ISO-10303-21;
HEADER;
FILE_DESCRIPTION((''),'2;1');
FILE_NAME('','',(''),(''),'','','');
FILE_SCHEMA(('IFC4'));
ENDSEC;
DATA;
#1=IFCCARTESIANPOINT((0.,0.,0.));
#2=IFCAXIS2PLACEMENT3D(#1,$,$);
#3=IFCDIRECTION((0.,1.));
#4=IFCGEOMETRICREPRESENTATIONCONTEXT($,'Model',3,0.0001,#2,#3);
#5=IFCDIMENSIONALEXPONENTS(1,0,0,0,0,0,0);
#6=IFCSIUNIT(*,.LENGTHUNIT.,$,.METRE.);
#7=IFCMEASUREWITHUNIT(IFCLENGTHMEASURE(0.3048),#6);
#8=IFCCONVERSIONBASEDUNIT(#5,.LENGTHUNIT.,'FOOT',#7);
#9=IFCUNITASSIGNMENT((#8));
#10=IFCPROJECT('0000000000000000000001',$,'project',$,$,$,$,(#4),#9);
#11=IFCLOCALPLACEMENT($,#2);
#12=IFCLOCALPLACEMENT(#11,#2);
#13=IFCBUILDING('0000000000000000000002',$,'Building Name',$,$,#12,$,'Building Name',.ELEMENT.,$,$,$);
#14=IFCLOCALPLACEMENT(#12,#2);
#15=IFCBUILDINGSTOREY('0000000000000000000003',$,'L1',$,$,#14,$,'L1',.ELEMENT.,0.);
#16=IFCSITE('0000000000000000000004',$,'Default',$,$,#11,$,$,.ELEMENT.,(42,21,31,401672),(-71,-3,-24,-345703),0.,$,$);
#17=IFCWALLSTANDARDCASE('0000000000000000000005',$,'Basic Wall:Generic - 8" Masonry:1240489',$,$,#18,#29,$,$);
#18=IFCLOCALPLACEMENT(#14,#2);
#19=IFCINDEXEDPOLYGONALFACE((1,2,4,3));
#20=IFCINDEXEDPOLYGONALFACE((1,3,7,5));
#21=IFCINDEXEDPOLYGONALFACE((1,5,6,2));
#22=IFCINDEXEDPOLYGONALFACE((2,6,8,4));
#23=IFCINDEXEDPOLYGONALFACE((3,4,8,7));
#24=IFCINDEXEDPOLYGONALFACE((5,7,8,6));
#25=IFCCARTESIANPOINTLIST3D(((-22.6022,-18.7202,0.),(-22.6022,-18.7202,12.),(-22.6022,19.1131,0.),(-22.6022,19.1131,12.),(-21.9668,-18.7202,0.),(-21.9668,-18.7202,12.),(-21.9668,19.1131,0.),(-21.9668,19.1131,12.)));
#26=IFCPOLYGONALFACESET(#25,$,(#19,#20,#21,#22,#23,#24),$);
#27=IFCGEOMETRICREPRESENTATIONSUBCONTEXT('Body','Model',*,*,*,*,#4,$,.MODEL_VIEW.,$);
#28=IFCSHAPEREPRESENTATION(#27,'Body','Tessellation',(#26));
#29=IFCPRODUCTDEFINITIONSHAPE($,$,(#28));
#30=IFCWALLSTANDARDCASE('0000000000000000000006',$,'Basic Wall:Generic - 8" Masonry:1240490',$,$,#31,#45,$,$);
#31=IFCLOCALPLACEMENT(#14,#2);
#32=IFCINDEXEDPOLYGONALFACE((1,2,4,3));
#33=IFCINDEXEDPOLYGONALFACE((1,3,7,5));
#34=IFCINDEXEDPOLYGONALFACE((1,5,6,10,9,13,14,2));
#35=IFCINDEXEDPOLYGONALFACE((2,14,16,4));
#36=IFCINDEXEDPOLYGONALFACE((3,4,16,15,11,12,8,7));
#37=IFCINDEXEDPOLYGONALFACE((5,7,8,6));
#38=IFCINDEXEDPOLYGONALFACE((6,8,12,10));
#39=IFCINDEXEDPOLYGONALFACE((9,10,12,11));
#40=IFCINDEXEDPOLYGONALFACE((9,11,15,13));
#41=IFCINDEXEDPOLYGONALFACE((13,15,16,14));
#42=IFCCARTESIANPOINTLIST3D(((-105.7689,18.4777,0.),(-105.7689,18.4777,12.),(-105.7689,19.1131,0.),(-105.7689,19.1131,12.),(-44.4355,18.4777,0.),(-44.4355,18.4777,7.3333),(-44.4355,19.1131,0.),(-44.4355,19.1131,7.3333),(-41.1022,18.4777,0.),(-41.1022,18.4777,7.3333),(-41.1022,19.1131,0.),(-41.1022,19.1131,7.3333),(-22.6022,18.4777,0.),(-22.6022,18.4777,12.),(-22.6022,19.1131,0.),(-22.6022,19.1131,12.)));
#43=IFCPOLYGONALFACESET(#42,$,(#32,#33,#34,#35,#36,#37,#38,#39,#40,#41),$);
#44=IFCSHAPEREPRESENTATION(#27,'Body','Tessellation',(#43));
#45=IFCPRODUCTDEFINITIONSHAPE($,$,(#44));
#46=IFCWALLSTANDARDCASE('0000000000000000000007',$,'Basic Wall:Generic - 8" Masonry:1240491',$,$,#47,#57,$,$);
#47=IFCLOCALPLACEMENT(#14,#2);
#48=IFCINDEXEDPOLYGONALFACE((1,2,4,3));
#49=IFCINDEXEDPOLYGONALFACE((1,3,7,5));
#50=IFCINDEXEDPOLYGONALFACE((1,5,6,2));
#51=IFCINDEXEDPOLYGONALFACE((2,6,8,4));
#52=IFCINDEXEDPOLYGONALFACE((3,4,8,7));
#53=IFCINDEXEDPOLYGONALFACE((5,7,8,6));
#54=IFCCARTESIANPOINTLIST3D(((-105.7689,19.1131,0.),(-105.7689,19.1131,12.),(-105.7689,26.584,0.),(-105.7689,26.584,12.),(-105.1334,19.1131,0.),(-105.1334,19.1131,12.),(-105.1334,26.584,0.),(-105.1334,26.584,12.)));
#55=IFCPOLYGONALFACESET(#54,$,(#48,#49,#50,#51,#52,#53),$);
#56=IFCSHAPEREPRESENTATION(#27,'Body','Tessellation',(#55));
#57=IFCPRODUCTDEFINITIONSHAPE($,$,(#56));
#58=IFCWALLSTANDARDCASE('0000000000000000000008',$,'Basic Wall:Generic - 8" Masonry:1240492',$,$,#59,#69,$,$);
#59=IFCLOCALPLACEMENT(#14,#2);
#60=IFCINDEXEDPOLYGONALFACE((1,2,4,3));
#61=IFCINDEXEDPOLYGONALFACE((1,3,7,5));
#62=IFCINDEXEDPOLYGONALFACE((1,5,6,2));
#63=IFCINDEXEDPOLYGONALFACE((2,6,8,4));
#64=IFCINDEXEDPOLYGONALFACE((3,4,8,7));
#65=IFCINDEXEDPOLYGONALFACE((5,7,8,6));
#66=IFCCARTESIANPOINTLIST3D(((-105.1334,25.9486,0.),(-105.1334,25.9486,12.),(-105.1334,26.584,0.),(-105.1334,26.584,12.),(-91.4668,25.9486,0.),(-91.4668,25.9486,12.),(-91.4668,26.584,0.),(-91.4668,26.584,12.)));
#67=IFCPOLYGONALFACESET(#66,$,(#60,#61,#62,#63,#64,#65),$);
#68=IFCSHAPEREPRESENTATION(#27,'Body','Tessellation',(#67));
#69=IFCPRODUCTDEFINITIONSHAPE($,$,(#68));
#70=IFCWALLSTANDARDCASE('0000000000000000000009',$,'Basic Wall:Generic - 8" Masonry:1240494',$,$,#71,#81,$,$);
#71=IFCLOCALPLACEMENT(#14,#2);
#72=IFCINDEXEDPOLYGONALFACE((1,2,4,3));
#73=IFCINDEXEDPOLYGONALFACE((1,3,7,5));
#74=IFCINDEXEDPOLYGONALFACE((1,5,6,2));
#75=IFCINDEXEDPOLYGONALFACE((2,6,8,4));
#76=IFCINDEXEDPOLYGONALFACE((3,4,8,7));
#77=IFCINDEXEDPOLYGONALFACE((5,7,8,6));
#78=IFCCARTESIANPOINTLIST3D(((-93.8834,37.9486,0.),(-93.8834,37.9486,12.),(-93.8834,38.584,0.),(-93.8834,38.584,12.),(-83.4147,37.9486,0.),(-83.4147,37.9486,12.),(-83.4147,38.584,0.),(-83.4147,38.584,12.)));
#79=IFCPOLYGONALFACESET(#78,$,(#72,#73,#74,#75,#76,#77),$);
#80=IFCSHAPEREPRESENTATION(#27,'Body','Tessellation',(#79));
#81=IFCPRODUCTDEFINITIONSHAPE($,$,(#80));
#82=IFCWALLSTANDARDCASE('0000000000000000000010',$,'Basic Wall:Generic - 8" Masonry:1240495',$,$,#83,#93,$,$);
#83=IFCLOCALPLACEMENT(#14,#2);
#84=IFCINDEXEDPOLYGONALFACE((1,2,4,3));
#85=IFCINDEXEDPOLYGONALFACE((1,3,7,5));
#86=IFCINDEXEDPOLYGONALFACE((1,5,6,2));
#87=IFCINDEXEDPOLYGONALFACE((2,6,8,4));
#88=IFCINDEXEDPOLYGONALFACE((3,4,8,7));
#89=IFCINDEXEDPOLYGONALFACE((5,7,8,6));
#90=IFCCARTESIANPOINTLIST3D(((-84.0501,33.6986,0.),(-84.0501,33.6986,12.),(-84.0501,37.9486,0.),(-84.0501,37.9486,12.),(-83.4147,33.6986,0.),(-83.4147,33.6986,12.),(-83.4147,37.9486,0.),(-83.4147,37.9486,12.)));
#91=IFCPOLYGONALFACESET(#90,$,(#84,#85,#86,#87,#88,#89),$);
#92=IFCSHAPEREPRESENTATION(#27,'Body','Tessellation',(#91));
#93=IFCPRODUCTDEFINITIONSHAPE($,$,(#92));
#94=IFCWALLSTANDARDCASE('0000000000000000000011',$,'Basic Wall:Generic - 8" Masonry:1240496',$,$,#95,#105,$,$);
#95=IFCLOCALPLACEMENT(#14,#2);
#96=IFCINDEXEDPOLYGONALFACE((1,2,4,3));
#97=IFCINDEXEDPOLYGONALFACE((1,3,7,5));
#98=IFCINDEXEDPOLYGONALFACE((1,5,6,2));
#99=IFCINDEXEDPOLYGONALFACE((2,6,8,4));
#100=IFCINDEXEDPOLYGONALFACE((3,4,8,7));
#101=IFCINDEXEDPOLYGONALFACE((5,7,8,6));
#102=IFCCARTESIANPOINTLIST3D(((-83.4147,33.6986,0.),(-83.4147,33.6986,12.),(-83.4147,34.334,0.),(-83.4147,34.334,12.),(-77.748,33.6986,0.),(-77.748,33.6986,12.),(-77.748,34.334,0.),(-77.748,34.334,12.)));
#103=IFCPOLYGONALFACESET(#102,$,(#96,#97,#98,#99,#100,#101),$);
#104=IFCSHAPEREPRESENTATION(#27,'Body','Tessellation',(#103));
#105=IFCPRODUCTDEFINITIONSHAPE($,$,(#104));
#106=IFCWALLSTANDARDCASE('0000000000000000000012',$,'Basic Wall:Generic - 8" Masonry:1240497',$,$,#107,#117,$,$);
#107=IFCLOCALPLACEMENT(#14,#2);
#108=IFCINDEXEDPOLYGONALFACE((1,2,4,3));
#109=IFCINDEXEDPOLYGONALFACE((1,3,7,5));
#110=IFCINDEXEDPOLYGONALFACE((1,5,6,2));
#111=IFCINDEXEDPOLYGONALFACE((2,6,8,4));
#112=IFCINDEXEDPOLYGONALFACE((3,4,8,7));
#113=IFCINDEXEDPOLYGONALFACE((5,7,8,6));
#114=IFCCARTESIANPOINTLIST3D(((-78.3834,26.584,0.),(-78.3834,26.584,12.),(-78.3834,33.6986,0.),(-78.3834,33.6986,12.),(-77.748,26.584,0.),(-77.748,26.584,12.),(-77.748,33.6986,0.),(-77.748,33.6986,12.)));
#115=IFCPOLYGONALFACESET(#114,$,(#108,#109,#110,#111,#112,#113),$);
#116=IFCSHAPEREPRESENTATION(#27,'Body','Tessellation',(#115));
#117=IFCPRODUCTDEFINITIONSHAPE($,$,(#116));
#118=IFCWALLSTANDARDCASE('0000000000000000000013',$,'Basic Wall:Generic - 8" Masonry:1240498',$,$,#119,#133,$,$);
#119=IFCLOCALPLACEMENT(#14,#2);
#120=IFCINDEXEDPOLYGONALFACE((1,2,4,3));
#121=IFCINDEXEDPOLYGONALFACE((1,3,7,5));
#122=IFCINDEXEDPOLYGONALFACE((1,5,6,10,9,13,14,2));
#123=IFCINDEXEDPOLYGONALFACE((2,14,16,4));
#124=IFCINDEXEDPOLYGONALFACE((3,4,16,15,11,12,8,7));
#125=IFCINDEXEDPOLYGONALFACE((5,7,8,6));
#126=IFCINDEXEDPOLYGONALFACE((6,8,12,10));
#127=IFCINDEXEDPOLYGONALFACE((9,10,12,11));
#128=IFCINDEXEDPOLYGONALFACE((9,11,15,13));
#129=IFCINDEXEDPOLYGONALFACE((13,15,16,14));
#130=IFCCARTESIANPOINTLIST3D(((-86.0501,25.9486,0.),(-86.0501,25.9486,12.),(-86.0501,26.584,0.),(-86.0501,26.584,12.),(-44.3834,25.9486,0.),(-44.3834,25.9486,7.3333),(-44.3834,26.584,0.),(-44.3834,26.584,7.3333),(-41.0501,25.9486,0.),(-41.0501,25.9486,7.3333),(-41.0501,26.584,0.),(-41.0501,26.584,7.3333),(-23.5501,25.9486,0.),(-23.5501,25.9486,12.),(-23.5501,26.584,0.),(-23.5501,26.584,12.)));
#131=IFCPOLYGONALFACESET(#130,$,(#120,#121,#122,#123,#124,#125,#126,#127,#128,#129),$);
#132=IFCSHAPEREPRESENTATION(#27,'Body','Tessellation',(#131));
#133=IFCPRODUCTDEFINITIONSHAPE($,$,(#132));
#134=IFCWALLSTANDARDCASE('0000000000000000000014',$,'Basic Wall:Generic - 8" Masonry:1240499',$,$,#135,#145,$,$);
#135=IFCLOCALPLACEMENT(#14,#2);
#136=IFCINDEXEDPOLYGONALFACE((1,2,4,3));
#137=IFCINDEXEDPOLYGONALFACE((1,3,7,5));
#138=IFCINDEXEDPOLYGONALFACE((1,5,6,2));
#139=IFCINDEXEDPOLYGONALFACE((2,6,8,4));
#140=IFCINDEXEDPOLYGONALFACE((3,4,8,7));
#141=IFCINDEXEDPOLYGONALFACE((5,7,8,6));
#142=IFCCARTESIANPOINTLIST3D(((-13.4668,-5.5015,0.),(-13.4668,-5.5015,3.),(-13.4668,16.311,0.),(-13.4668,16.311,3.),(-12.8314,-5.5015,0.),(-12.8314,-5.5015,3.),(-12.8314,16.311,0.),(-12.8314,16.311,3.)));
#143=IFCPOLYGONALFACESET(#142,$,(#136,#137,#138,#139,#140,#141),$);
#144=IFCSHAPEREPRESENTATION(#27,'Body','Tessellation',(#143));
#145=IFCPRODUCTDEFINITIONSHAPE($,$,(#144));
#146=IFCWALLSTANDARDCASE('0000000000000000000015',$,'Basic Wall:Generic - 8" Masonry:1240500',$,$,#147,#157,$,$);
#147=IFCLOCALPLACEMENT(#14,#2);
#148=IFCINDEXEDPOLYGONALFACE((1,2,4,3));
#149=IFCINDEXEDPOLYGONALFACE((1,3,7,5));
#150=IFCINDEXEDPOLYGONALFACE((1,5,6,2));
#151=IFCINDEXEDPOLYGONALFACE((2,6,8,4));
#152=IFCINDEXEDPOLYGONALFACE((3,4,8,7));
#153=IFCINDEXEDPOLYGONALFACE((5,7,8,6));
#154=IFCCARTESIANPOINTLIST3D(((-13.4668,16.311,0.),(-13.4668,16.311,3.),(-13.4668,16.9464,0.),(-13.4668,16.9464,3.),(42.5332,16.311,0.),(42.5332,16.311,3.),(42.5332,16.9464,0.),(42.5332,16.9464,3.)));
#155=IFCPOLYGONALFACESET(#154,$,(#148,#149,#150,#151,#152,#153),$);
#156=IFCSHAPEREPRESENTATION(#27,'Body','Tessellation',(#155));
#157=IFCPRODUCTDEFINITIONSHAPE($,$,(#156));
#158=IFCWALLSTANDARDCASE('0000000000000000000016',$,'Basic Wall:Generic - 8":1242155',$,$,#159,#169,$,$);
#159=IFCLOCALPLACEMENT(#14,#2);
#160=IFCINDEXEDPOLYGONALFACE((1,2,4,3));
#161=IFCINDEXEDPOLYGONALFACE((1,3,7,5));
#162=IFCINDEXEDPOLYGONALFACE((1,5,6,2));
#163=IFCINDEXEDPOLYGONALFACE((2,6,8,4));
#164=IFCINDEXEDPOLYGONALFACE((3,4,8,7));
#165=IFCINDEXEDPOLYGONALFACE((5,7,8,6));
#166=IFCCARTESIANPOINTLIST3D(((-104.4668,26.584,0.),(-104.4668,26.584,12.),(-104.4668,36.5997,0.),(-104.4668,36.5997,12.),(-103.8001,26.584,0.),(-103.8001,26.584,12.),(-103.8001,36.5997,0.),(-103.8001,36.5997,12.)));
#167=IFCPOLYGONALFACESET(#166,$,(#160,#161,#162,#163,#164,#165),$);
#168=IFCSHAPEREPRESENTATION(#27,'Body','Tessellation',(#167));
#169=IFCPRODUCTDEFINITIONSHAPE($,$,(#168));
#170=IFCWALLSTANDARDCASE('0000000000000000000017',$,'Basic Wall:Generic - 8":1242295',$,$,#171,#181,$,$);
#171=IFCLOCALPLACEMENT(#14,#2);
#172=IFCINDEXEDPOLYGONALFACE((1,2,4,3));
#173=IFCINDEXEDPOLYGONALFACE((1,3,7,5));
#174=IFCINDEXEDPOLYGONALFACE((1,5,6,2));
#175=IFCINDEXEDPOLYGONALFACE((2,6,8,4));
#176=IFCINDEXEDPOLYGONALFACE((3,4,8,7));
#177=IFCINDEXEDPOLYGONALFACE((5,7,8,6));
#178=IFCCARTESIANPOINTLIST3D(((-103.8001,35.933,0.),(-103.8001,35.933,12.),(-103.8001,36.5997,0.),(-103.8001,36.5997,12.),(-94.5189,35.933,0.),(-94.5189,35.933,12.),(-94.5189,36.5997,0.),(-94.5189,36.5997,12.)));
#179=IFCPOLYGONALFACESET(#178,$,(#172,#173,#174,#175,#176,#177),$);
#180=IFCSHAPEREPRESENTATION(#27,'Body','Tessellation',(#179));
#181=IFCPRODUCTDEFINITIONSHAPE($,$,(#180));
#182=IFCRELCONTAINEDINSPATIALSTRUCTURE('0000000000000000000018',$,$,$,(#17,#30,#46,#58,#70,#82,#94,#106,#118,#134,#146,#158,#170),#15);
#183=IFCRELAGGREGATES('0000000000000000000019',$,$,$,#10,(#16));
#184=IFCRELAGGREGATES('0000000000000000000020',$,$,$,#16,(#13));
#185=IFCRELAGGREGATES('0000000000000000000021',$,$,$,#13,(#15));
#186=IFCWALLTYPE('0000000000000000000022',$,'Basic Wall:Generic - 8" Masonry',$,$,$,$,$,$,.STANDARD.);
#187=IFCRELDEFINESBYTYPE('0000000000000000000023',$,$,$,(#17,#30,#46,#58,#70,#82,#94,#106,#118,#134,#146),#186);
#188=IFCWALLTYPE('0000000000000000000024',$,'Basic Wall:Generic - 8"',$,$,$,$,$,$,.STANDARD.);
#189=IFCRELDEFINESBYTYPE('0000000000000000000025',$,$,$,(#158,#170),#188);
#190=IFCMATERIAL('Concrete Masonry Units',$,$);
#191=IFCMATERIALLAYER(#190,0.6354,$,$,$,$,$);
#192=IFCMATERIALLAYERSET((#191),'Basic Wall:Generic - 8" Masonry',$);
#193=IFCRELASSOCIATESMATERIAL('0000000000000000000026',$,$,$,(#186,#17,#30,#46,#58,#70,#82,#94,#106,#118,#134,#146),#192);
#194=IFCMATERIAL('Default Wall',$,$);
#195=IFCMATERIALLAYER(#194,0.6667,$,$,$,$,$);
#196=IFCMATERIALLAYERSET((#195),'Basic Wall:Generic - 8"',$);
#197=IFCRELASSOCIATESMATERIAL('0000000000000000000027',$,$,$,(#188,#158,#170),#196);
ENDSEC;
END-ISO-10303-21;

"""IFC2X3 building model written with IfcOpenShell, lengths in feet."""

from ifc_helpers import new_model, entity, si_unit, converted_unit, direction, frame, frame_2d, origin, place, context, subcontext, project, spatial, rectangle, extrude, material, layer, layer_set, layer_usage, type_object, element, save


model = new_model("IFC2X3")

# Units and contexts
model_context = context("Model", 3, precision=0.0001, world=origin(), true_north=direction((0.0, 1.0)))
body_context = subcontext(model_context, "Body", "Model", "MODEL_VIEW")
ifc_project = project(units=[converted_unit("LENGTHUNIT", "FOOT", entity("IfcLengthMeasure", 0.3048), si_unit("LENGTHUNIT", "METRE"), dimensions=[1, 0, 0, 0, 0, 0, 0])], contexts=[model_context])

# Site, building, storey
site_placement = place(None, origin())
site = spatial("IfcSite", under=ifc_project, at=site_placement, Name="Default", CompositionType="ELEMENT", RefLatitude=(42, 21, 31, 401672), RefLongitude=(-71, -3, -24, -345703), RefElevation=0.0)
building_placement = place(site_placement, origin())
building = spatial("IfcBuilding", under=site, at=building_placement, Name="Building Name", LongName="Building Name", CompositionType="ELEMENT")
storey_placement = place(building_placement, origin())
storey = spatial("IfcBuildingStorey", under=building, at=storey_placement, Name="L1", LongName="L1", CompositionType="ELEMENT", Elevation=0.0)

# Wall
ifc_material_1 = material(Name="Concrete Masonry Units")
ifc_layer_1 = layer(ifc_material_1, 0.6354)
ifc_layer_set_1 = layer_set([ifc_layer_1], Name="Basic Wall:Generic - 8\" Masonry")
ifc_layer_usage_1 = layer_usage(ifc_layer_set_1, "AXIS2", "NEGATIVE", 0.3177)
wall_type_1 = type_object("IfcWallType", Name="Basic Wall:Generic - 8\" Masonry", PredefinedType="STANDARD", material=ifc_layer_set_1)
wall_1_placement = place(storey_placement, frame((-22.2845, 19.1131, 0.0), z_axis=(0.0, 0.0, 1.0), x_axis=(0.0, -1.0, 0.0)))
element("IfcWallStandardCase", 1, at=wall_1_placement, inside=storey, type_object=wall_type_1, material=ifc_layer_usage_1, Name="Basic Wall:Generic - 8\" Masonry:1240489", context=body_context, shape_type="SweptSolid", body=[
    extrude(rectangle(XDim=37.8333, YDim=0.6354, at=frame_2d((18.9167, 0.0), x_axis=(-1.0, 0.0))), origin(), (0.0, 0.0, 1.0), 12.0),
])

# Wall, opening
ifc_layer_usage_2 = layer_usage(ifc_layer_set_1, "AXIS2", "NEGATIVE", 0.3177)
wall_2_placement = place(storey_placement, frame((-22.6022, 18.7954, 0.0), z_axis=(0.0, 0.0, 1.0), x_axis=(-1.0, 0.0, 0.0)))
wall_2 = element("IfcWallStandardCase", 2, at=wall_2_placement, inside=storey, type_object=wall_type_1, material=ifc_layer_usage_2, Name="Basic Wall:Generic - 8\" Masonry:1240490", context=body_context, shape_type="SweptSolid", body=[
    extrude(rectangle(XDim=83.1667, YDim=0.6354, at=frame_2d((41.5833, 0.0), x_axis=(1.0, 0.0))), origin(), (0.0, 0.0, 1.0), 12.0),
])
opening_1_placement = place(wall_2_placement, frame((18.5, -0.3177, 0.0)))
element("IfcOpeningElement", 3, at=opening_1_placement, cuts=wall_2, ObjectType="Opening", context=body_context, shape_type="SweptSolid", body=[
    extrude(rectangle(XDim=7.3333, YDim=3.3333, at=frame_2d((3.6667, 1.6667), x_axis=(1.0, 0.0))), frame((0.0, 0.0, 0.0), z_axis=(0.0, 1.0, 0.0), x_axis=(0.0, 0.0, 1.0)), (0.0, 0.0, 1.0), 0.6354),
])

# Walls
ifc_layer_usage_3 = layer_usage(ifc_layer_set_1, "AXIS2", "NEGATIVE", 0.3177)
wall_3_placement = place(storey_placement, frame((-105.4511, 19.1131, 0.0), z_axis=(0.0, 0.0, 1.0), x_axis=(0.0, 1.0, 0.0)))
element("IfcWallStandardCase", 4, at=wall_3_placement, inside=storey, type_object=wall_type_1, material=ifc_layer_usage_3, Name="Basic Wall:Generic - 8\" Masonry:1240491", context=body_context, shape_type="SweptSolid", body=[
    extrude(rectangle(XDim=7.4709, YDim=0.6354, at=frame_2d((3.7355, 0.0), x_axis=(-1.0, 0.0))), origin(), (0.0, 0.0, 1.0), 12.0),
])
ifc_layer_usage_4 = layer_usage(ifc_layer_set_1, "AXIS2", "NEGATIVE", 0.3177)
wall_4_placement = place(storey_placement, frame((-105.1334, 26.2663, 0.0)))
element("IfcWallStandardCase", 5, at=wall_4_placement, inside=storey, type_object=wall_type_1, material=ifc_layer_usage_4, Name="Basic Wall:Generic - 8\" Masonry:1240492", context=body_context, shape_type="SweptSolid", body=[
    extrude(rectangle(XDim=13.6667, YDim=0.6354, at=frame_2d((6.8333, 0.0), x_axis=(-1.0, 0.0))), origin(), (0.0, 0.0, 1.0), 12.0),
])

# Walls
ifc_layer_usage_5 = layer_usage(ifc_layer_set_1, "AXIS2", "NEGATIVE", 0.3177)
wall_5_placement = place(storey_placement, frame((-93.8834, 38.2663, 0.0)))
element("IfcWallStandardCase", 6, at=wall_5_placement, inside=storey, type_object=wall_type_1, material=ifc_layer_usage_5, Name="Basic Wall:Generic - 8\" Masonry:1240494", context=body_context, shape_type="SweptSolid", body=[
    extrude(rectangle(XDim=10.4687, YDim=0.6354, at=frame_2d((5.2344, 0.0), x_axis=(-1.0, 0.0))), origin(), (0.0, 0.0, 1.0), 12.0),
])
ifc_layer_usage_6 = layer_usage(ifc_layer_set_1, "AXIS2", "NEGATIVE", 0.3177)
wall_6_placement = place(storey_placement, frame((-83.7324, 37.9486, 0.0), z_axis=(0.0, 0.0, 1.0), x_axis=(0.0, -1.0, 0.0)))
element("IfcWallStandardCase", 7, at=wall_6_placement, inside=storey, type_object=wall_type_1, material=ifc_layer_usage_6, Name="Basic Wall:Generic - 8\" Masonry:1240495", context=body_context, shape_type="SweptSolid", body=[
    extrude(rectangle(XDim=4.25, YDim=0.6354, at=frame_2d((2.125, 0.0), x_axis=(-1.0, 0.0))), origin(), (0.0, 0.0, 1.0), 12.0),
])
ifc_layer_usage_7 = layer_usage(ifc_layer_set_1, "AXIS2", "NEGATIVE", 0.3177)
wall_7_placement = place(storey_placement, frame((-83.4147, 34.0163, 0.0)))
element("IfcWallStandardCase", 8, at=wall_7_placement, inside=storey, type_object=wall_type_1, material=ifc_layer_usage_7, Name="Basic Wall:Generic - 8\" Masonry:1240496", context=body_context, shape_type="SweptSolid", body=[
    extrude(rectangle(XDim=5.6667, YDim=0.6354, at=frame_2d((2.8333, 0.0), x_axis=(-1.0, 0.0))), origin(), (0.0, 0.0, 1.0), 12.0),
])
ifc_layer_usage_8 = layer_usage(ifc_layer_set_1, "AXIS2", "NEGATIVE", 0.3177)
wall_8_placement = place(storey_placement, frame((-78.0657, 33.6986, 0.0), z_axis=(0.0, 0.0, 1.0), x_axis=(0.0, -1.0, 0.0)))
element("IfcWallStandardCase", 9, at=wall_8_placement, inside=storey, type_object=wall_type_1, material=ifc_layer_usage_8, Name="Basic Wall:Generic - 8\" Masonry:1240497", context=body_context, shape_type="SweptSolid", body=[
    extrude(rectangle(XDim=7.1146, YDim=0.6354, at=frame_2d((3.5573, 0.0), x_axis=(1.0, 0.0))), origin(), (0.0, 0.0, 1.0), 12.0),
])

# Wall, opening
ifc_layer_usage_9 = layer_usage(ifc_layer_set_1, "AXIS2", "NEGATIVE", 0.3177)
wall_9_placement = place(storey_placement, frame((-23.5501, 26.2663, 0.0), z_axis=(0.0, 0.0, 1.0), x_axis=(-1.0, 0.0, 0.0)))
wall_9 = element("IfcWallStandardCase", 10, at=wall_9_placement, inside=storey, type_object=wall_type_1, material=ifc_layer_usage_9, Name="Basic Wall:Generic - 8\" Masonry:1240498", context=body_context, shape_type="SweptSolid", body=[
    extrude(rectangle(XDim=62.5, YDim=0.6354, at=frame_2d((31.25, 0.0), x_axis=(1.0, 0.0))), origin(), (0.0, 0.0, 1.0), 12.0),
])
opening_2_placement = place(wall_9_placement, frame((20.8333, 0.3177, 0.0)))
element("IfcOpeningElement", 11, at=opening_2_placement, cuts=wall_9, ObjectType="Opening", context=body_context, shape_type="SweptSolid", body=[
    extrude(rectangle(XDim=7.3333, YDim=3.3333, at=frame_2d((3.6667, 1.6667), x_axis=(1.0, 0.0))), frame((0.0, 0.0, 0.0), z_axis=(0.0, -1.0, 0.0), x_axis=(0.0, 0.0, 1.0)), (0.0, 0.0, 1.0), 0.6354),
])

# Walls
ifc_layer_usage_10 = layer_usage(ifc_layer_set_1, "AXIS2", "NEGATIVE", 0.3177)
wall_10_placement = place(storey_placement, frame((-13.1491, -5.5015, 0.0), z_axis=(0.0, 0.0, 1.0), x_axis=(0.0, 1.0, 0.0)))
element("IfcWallStandardCase", 12, at=wall_10_placement, inside=storey, type_object=wall_type_1, material=ifc_layer_usage_10, Name="Basic Wall:Generic - 8\" Masonry:1240499", context=body_context, shape_type="SweptSolid", body=[
    extrude(rectangle(XDim=21.8125, YDim=0.6354, at=frame_2d((10.9063, 0.0), x_axis=(-1.0, 0.0))), origin(), (0.0, 0.0, 1.0), 3.0),
])
ifc_layer_usage_11 = layer_usage(ifc_layer_set_1, "AXIS2", "NEGATIVE", 0.3177)
wall_11_placement = place(storey_placement, frame((-13.4668, 16.6287, 0.0)))
element("IfcWallStandardCase", 13, at=wall_11_placement, inside=storey, type_object=wall_type_1, material=ifc_layer_usage_11, Name="Basic Wall:Generic - 8\" Masonry:1240500", context=body_context, shape_type="SweptSolid", body=[
    extrude(rectangle(XDim=56.0, YDim=0.6354, at=frame_2d((28.0, 0.0), x_axis=(-1.0, 0.0))), origin(), (0.0, 0.0, 1.0), 3.0),
])
ifc_material_2 = material(Name="Default Wall")
ifc_layer_2 = layer(ifc_material_2, 0.6667)
ifc_layer_set_2 = layer_set([ifc_layer_2], Name="Basic Wall:Generic - 8\"")
ifc_layer_usage_12 = layer_usage(ifc_layer_set_2, "AXIS2", "NEGATIVE", 0.3333)
wall_type_2 = type_object("IfcWallType", Name="Basic Wall:Generic - 8\"", PredefinedType="STANDARD", material=ifc_layer_set_2)
wall_12_placement = place(storey_placement, frame((-104.1334, 26.584, 0.0), z_axis=(0.0, 0.0, 1.0), x_axis=(0.0, 1.0, 0.0)))
element("IfcWallStandardCase", 14, at=wall_12_placement, inside=storey, type_object=wall_type_2, material=ifc_layer_usage_12, Name="Basic Wall:Generic - 8\":1242155", context=body_context, shape_type="SweptSolid", body=[
    extrude(rectangle(XDim=10.0156, YDim=0.6667, at=frame_2d((5.0078, 0.0), x_axis=(-1.0, 0.0))), origin(), (0.0, 0.0, 1.0), 12.0),
])
ifc_layer_usage_13 = layer_usage(ifc_layer_set_2, "AXIS2", "POSITIVE", -0.3333)
wall_13_placement = place(storey_placement, frame((-103.8001, 36.2663, 0.0)))
element("IfcWallStandardCase", 15, at=wall_13_placement, inside=storey, type_object=wall_type_2, material=ifc_layer_usage_13, Name="Basic Wall:Generic - 8\":1242295", context=body_context, shape_type="SweptSolid", body=[
    extrude(rectangle(XDim=9.2812, YDim=0.6667, at=frame_2d((4.6406, 0.0), x_axis=(-1.0, 0.0))), origin(), (0.0, 0.0, 1.0), 12.0),
])

save(model, "model.ifc")
